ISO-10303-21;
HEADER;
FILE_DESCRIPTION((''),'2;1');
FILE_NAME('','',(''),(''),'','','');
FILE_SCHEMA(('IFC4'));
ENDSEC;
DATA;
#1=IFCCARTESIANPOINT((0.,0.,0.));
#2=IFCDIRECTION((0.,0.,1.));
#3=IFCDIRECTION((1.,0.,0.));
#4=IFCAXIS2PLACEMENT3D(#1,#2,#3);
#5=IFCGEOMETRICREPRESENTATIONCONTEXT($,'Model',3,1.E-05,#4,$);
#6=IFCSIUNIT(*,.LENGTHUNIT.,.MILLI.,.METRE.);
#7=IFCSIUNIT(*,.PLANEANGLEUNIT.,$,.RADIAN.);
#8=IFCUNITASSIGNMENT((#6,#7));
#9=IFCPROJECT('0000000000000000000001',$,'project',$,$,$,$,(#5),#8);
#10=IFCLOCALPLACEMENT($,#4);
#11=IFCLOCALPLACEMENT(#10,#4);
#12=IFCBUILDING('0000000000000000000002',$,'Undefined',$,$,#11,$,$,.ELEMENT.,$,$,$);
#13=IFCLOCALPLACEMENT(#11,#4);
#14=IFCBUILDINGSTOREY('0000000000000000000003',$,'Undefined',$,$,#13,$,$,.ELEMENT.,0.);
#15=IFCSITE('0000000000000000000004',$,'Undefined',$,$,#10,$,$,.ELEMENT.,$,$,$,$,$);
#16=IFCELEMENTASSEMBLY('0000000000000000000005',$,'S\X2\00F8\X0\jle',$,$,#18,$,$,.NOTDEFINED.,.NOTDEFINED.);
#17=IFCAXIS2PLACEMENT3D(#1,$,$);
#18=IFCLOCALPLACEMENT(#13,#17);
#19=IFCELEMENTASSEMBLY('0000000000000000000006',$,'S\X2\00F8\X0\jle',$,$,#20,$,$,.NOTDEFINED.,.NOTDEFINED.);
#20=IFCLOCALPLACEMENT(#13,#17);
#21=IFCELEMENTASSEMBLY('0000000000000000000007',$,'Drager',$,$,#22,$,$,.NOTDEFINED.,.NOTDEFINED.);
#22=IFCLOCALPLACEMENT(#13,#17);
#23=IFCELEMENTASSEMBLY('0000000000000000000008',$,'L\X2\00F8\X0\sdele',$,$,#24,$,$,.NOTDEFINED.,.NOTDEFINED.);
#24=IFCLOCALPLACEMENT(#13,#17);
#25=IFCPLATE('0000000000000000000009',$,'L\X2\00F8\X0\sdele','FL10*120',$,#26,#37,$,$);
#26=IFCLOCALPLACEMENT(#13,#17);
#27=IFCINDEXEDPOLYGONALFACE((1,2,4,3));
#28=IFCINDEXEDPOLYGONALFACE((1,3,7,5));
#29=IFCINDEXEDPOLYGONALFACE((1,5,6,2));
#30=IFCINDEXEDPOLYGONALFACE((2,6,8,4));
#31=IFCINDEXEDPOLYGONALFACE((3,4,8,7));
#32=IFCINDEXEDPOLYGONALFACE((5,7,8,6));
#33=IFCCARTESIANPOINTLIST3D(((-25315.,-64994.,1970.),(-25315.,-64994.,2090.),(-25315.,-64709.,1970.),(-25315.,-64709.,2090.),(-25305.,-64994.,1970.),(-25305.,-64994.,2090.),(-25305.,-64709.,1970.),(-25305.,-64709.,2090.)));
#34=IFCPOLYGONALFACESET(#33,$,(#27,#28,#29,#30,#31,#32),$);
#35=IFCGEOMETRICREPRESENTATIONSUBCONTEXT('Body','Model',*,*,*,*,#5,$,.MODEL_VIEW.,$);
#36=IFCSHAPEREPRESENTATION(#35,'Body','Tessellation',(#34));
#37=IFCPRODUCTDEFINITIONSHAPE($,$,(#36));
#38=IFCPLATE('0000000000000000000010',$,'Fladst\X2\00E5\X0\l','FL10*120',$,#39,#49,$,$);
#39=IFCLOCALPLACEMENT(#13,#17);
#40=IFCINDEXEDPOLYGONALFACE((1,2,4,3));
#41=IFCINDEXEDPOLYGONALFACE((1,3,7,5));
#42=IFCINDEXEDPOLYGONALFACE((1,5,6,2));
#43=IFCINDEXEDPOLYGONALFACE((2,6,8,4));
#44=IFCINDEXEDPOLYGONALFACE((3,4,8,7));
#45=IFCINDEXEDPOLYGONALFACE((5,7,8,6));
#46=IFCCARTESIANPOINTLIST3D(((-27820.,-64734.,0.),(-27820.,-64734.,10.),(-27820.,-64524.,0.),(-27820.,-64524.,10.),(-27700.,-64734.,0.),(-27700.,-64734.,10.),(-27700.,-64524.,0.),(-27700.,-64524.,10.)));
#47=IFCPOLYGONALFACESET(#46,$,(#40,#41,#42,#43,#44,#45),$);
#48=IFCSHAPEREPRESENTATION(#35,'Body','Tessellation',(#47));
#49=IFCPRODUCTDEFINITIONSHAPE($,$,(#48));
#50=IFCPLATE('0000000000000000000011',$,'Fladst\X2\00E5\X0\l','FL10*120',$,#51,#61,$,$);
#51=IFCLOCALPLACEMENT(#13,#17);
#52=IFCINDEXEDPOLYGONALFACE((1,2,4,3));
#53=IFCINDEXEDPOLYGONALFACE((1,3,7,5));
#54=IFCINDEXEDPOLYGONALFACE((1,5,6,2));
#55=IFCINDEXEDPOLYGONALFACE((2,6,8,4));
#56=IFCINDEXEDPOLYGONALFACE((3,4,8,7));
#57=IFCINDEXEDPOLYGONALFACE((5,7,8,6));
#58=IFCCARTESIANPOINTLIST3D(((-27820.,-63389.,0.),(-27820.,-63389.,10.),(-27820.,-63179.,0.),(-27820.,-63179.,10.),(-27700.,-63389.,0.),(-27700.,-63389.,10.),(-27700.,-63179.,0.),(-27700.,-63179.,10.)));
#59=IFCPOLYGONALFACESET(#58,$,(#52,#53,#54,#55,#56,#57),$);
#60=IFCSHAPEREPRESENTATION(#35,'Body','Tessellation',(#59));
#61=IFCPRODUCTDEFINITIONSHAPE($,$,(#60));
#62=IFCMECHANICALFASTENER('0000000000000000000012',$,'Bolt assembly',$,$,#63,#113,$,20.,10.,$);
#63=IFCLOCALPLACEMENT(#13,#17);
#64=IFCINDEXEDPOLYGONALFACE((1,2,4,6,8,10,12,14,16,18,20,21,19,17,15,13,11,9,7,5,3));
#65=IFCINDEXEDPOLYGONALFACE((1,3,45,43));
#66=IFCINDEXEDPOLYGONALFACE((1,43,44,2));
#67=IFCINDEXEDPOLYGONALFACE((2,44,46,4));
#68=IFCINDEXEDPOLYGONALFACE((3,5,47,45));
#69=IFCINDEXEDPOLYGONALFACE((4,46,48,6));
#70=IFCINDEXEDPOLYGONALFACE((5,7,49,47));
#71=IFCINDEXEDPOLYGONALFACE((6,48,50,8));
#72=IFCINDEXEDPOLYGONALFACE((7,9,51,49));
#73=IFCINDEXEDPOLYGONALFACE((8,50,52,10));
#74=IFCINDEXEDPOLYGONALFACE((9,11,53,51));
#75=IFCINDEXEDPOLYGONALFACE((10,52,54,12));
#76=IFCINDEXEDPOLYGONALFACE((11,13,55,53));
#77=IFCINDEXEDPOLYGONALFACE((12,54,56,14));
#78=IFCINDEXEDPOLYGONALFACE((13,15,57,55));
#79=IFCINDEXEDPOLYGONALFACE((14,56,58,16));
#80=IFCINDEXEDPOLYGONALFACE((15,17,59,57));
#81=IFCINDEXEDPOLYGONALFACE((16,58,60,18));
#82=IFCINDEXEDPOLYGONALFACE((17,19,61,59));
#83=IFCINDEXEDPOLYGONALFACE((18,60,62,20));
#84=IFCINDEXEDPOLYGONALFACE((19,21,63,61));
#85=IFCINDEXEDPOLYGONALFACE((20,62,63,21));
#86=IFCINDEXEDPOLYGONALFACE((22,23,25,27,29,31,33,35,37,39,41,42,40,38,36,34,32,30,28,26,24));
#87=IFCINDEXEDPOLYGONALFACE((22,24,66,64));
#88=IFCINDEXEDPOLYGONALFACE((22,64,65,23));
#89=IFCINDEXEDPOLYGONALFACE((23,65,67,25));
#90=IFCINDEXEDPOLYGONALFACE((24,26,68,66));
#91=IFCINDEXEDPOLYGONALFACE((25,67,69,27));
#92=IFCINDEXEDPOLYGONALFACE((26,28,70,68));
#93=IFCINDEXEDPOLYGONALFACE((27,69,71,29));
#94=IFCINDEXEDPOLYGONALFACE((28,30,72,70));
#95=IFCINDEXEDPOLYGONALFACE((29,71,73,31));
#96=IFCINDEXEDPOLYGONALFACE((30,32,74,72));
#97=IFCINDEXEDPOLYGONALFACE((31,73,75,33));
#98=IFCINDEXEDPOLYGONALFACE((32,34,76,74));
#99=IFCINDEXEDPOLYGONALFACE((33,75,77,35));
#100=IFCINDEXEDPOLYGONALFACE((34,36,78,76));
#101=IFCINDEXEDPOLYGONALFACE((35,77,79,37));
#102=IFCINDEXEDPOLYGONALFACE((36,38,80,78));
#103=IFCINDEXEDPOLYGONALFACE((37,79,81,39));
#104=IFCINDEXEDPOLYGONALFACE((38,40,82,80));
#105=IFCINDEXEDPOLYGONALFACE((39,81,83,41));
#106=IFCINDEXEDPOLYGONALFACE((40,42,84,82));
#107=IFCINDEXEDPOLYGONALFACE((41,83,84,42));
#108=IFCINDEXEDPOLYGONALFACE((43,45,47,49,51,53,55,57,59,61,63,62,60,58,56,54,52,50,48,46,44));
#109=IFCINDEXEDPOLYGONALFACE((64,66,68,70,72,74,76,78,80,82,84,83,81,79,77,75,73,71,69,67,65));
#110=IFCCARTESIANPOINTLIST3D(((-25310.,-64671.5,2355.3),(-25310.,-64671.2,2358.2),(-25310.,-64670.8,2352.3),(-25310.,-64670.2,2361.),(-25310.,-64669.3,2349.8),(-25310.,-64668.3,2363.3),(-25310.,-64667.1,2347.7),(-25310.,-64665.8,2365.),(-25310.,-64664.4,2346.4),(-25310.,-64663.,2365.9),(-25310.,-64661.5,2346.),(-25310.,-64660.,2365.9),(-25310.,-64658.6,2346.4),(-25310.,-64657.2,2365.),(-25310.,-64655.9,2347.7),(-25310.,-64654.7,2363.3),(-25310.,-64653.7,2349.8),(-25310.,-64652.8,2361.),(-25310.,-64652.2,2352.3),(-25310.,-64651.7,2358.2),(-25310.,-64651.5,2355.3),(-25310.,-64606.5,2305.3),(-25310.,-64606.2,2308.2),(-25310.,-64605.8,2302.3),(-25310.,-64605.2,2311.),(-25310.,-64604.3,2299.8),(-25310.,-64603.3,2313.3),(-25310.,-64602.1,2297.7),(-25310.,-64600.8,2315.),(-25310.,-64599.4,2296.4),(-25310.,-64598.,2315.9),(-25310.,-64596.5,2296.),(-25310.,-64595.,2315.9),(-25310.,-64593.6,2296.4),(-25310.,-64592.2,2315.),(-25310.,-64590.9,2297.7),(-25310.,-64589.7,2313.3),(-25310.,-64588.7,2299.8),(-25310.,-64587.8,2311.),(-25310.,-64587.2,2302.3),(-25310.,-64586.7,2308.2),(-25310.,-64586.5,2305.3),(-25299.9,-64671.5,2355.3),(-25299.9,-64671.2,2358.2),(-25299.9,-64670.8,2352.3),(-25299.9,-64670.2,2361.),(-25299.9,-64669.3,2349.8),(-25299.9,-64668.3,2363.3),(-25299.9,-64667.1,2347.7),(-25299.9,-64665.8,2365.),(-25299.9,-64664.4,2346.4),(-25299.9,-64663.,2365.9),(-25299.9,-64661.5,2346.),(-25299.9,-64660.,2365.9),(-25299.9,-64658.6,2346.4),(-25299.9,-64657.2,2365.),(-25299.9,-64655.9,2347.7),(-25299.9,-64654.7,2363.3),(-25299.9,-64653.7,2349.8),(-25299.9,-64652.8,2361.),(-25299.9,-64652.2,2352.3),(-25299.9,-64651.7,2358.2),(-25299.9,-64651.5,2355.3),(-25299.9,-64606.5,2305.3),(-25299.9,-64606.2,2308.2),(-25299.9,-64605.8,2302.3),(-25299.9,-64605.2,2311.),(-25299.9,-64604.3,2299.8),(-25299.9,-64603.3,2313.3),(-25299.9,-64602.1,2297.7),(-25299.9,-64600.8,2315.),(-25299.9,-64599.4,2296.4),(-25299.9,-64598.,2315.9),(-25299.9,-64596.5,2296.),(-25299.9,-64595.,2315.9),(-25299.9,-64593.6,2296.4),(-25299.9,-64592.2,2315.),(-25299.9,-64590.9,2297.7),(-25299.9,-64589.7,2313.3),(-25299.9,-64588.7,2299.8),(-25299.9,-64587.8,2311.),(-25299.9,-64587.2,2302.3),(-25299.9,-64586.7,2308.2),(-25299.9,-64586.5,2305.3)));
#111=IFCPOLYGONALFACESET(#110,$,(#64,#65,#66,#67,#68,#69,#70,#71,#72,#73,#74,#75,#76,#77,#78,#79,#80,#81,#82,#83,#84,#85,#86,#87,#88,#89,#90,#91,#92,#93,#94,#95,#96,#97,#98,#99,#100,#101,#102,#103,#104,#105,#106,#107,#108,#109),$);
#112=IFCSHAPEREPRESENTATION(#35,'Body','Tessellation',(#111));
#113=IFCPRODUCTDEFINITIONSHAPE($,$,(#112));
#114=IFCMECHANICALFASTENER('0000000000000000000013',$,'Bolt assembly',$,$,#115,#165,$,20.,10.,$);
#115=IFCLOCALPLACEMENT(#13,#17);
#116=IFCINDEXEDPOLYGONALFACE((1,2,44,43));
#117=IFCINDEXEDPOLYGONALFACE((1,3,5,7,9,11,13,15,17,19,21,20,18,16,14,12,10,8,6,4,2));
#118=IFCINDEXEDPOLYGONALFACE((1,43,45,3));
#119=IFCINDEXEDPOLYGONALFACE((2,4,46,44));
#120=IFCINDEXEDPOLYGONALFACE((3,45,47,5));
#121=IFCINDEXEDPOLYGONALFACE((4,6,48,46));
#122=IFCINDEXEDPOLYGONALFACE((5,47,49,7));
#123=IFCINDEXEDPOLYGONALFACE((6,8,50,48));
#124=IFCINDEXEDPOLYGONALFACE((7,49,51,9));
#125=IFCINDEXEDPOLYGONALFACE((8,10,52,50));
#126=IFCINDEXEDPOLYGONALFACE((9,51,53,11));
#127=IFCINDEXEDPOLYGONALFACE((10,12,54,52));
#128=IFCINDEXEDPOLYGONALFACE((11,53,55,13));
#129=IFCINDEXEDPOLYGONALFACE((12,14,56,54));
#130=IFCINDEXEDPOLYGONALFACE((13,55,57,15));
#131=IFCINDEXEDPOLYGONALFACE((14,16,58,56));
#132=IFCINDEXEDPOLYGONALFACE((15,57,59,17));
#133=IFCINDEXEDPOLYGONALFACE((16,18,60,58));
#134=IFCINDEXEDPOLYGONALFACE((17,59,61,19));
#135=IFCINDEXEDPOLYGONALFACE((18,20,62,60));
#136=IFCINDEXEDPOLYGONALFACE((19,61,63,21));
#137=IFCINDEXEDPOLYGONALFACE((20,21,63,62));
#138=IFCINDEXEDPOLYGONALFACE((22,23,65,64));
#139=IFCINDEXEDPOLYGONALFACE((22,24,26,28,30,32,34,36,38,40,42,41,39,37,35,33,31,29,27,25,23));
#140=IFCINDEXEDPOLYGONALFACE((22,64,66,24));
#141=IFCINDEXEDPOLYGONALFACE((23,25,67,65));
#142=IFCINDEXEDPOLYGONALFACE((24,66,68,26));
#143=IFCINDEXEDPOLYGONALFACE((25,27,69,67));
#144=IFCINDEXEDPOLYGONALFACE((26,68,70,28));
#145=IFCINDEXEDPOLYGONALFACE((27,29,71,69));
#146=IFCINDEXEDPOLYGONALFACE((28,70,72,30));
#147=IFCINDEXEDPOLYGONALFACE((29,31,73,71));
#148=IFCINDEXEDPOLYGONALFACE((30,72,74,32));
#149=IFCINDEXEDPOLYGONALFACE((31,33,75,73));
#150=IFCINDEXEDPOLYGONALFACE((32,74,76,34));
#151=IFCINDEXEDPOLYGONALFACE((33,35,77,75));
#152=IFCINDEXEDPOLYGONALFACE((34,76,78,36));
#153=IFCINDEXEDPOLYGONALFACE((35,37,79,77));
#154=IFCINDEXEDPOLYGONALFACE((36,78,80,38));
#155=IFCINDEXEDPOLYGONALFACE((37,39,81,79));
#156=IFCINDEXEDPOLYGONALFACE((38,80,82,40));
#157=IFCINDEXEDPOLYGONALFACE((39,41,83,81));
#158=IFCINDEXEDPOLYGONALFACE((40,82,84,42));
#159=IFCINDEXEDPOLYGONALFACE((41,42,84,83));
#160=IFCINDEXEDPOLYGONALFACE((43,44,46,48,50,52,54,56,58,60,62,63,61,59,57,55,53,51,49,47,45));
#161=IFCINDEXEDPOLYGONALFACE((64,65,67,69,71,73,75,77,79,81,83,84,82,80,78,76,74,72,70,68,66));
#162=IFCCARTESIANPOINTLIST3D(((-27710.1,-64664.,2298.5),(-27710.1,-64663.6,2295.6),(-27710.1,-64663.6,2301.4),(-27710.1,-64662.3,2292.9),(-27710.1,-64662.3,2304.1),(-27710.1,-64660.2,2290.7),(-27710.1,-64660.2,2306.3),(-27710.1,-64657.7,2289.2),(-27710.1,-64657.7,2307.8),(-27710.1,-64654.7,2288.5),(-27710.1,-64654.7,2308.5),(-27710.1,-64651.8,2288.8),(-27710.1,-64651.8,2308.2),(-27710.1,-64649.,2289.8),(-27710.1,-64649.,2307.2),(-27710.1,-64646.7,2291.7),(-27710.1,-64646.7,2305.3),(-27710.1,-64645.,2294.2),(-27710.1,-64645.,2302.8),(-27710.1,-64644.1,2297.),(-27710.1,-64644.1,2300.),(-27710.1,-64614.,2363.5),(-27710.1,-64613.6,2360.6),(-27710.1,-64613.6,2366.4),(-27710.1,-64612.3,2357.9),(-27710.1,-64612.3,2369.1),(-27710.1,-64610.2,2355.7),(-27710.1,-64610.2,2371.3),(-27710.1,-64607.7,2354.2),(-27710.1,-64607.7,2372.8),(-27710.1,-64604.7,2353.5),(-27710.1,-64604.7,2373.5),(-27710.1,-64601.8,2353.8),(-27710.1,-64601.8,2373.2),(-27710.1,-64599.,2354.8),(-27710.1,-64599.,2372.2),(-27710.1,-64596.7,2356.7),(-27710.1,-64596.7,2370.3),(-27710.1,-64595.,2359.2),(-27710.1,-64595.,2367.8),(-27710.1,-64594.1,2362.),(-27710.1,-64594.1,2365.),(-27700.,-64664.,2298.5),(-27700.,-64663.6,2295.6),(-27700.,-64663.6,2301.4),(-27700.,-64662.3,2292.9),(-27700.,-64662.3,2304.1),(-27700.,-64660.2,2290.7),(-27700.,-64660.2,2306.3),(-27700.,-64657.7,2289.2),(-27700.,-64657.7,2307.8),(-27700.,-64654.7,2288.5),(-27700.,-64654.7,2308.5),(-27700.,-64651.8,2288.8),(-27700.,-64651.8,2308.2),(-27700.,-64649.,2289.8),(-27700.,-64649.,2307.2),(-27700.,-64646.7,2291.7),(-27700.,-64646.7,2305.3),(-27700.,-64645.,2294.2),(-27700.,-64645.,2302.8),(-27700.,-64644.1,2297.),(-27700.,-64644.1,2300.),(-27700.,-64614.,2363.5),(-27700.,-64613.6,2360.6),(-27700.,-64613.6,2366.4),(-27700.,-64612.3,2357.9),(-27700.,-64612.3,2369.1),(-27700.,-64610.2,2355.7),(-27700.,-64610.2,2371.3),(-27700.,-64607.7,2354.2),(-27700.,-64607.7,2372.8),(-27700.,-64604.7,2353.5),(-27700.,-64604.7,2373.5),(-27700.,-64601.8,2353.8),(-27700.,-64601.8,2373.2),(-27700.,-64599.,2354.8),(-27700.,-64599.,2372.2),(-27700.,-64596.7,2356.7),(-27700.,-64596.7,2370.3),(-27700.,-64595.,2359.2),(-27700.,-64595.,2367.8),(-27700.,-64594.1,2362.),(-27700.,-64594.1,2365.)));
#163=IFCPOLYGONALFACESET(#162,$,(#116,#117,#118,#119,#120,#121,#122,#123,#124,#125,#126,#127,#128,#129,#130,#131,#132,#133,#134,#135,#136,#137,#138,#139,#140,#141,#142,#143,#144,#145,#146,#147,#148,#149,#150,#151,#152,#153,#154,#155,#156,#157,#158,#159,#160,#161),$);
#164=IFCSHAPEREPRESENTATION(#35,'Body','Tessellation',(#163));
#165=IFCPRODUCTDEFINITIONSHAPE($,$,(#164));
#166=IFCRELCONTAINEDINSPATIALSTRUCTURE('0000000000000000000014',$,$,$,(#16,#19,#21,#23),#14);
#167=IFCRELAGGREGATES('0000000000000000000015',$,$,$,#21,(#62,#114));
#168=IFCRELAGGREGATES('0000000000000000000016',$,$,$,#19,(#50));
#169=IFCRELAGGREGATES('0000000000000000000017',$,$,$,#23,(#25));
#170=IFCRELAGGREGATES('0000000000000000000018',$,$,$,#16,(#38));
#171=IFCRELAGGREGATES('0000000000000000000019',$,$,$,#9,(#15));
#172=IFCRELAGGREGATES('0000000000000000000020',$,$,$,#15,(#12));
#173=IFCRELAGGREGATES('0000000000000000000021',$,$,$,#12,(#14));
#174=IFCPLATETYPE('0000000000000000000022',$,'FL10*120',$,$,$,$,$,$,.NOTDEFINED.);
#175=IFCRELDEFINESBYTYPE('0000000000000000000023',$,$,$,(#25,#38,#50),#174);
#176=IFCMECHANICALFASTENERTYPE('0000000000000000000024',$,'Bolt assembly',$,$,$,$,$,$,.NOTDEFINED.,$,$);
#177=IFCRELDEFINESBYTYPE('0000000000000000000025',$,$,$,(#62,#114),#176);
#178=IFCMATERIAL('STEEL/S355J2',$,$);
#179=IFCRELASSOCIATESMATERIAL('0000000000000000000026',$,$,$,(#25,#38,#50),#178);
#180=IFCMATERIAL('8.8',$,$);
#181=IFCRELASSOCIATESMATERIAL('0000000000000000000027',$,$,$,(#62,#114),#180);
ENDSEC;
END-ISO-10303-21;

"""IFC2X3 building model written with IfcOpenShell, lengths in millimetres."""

from ifc_helpers import new_model, si_unit, frame, origin_with_axes, origin_2d_with_axis, place, context, subcontext, project, spatial, polyline, circle, outline, extrude, source, transform, mapped, material, type_object, element, aggregate, save


model = new_model("IFC2X3")

# Units and contexts
model_context = context("Model", 3, precision=1e-05, world=origin_with_axes())
body_context = subcontext(model_context, "Body", "Model", "MODEL_VIEW")
ifc_project = project(units=[si_unit("LENGTHUNIT", "METRE", prefix="MILLI"), si_unit("PLANEANGLEUNIT", "RADIAN")], contexts=[model_context])

# Site, building, storey
site_placement = place(None, origin_with_axes())
site = spatial("IfcSite", under=ifc_project, at=site_placement, Name="Undefined", CompositionType="ELEMENT")
building_placement = place(site_placement, origin_with_axes())
building = spatial("IfcBuilding", under=site, at=building_placement, Name="Undefined", CompositionType="ELEMENT")
storey_placement = place(building_placement, origin_with_axes())
storey = spatial("IfcBuildingStorey", under=building, at=storey_placement, Name="Undefined", CompositionType="ELEMENT", Elevation=0.0)

# Element assemblies
assembly_1_placement = place(storey_placement, origin_with_axes())
assembly_1 = element("IfcElementAssembly", 1, at=assembly_1_placement, inside=storey, Name="Søjle", AssemblyPlace="NOTDEFINED", PredefinedType="NOTDEFINED")
assembly_2_placement = place(storey_placement, origin_with_axes())
assembly_2 = element("IfcElementAssembly", 2, at=assembly_2_placement, inside=storey, Name="Søjle", AssemblyPlace="NOTDEFINED", PredefinedType="NOTDEFINED")

# Element assembly
assembly_3_placement = place(storey_placement, origin_with_axes())
assembly_3 = element("IfcElementAssembly", 3, at=assembly_3_placement, inside=storey, Name="Drager", AssemblyPlace="NOTDEFINED", PredefinedType="NOTDEFINED")

# Shared definitions
ifc_material_1 = material(Name="STEEL/S355J2")

# Element assembly, plate
plate_type_1 = type_object("IfcPlateType", Name="FL10*120", PredefinedType="NOTDEFINED")
assembly_4_placement = place(storey_placement, origin_with_axes())
assembly_4 = element("IfcElementAssembly", 4, at=assembly_4_placement, inside=storey, Name="Løsdele", AssemblyPlace="NOTDEFINED", PredefinedType="NOTDEFINED")
plate_1_placement = place(assembly_4_placement, frame((-25310.0, -64994.0, 2030.0), z_axis=(1.0, 0.0, 0.0), x_axis=(0.0, 1.0, 0.0)))
plate_1 = element("IfcPlate", 5, at=plate_1_placement, type_object=plate_type_1, material=ifc_material_1, Name="Løsdele", Description="FL10*120", context=body_context, shape_type="SweptSolid", body=[
    extrude(outline(polyline([(0.0, -60.0), (0.0, 60.0), (285.0, 60.0), (285.0, -60.0), (0.0, -60.0)])), frame((0.0, 0.0, -5.0), z_axis=(0.0, 0.0, 1.0), x_axis=(1.0, 0.0, 0.0)), (0.0, 0.0, 1.0), 10.0),
])

# Plates
plate_2_placement = place(assembly_1_placement, frame((-27700.0, -64629.0, 5.0), z_axis=(0.0, 0.0, 1.0), x_axis=(-1.0, 0.0, 0.0)))
plate_2 = element("IfcPlate", 6, at=plate_2_placement, type_object=plate_type_1, material=ifc_material_1, Name="Fladstål", Description="FL10*120", context=body_context, shape_type="SweptSolid", body=[
    extrude(outline(polyline([(0.0, -105.0), (0.0, 105.0), (120.0, 105.0), (120.0, -105.0), (0.0, -105.0)])), frame((0.0, 0.0, -5.0), z_axis=(0.0, 0.0, 1.0), x_axis=(1.0, 0.0, 0.0)), (0.0, 0.0, 1.0), 10.0),
])
plate_3_placement = place(assembly_2_placement, frame((-27700.0, -63284.0, 5.0), z_axis=(0.0, 0.0, 1.0), x_axis=(-1.0, 0.0, 0.0)))
plate_3 = element("IfcPlate", 7, at=plate_3_placement, type_object=plate_type_1, material=ifc_material_1, Name="Fladstål", Description="FL10*120", context=body_context, shape_type="SweptSolid", body=[
    extrude(outline(polyline([(0.0, -105.0), (0.0, 105.0), (120.0, 105.0), (120.0, -105.0), (0.0, -105.0)])), frame((0.0, 0.0, -5.0), z_axis=(0.0, 0.0, 1.0), x_axis=(1.0, 0.0, 0.0)), (0.0, 0.0, 1.0), 10.0),
])

# Mechanical fasteners
ifc_material_2 = material(Name="8.8")
mechanical_fastener_type = type_object("IfcMechanicalFastenerType", Name="Bolt assembly")
shared_shape_1 = source(origin_with_axes(), body_context, "Body", "SweptSolid", [
    extrude(circle(Radius=10.0, at=origin_2d_with_axis()), frame((0.0, 0.0, 0.0), z_axis=(0.0, 1.0, 0.0), x_axis=(1.0, 0.0, 0.0)), (0.0, 0.0, 1.0), 10.1),
])
mechanical_fastener_1_placement = place(assembly_3_placement, frame((-25310.0, -64629.0, 2356.0), z_axis=(0.0, -1.0, 0.0), x_axis=(0.0, 0.0, -1.0)))
mechanical_fastener_1 = element("IfcMechanicalFastener", 8, at=mechanical_fastener_1_placement, type_object=mechanical_fastener_type, material=ifc_material_2, Name="Bolt assembly", NominalDiameter=20.0, NominalLength=10.0, context=body_context, shape_type="MappedRepresentation", body=[
    mapped(shared_shape_1, transform((50.0, 0.0, -32.5))),
    mapped(shared_shape_1, transform((0.0, 0.0, 32.5))),
])
mechanical_fastener_2_placement = place(assembly_3_placement, frame((-27700.0, -64604.0, 2331.0), z_axis=(0.0, 0.0, -1.0), x_axis=(0.0, -1.0, 0.0)))
mechanical_fastener_2 = element("IfcMechanicalFastener", 9, at=mechanical_fastener_2_placement, type_object=mechanical_fastener_type, material=ifc_material_2, Name="Bolt assembly", NominalDiameter=20.0, NominalLength=10.0, context=body_context, shape_type="MappedRepresentation", body=[
    mapped(shared_shape_1, transform((0.0, 0.0, -32.5))),
    mapped(shared_shape_1, transform((50.0, 0.0, 32.5))),
])
aggregate(assembly_3, [mechanical_fastener_1, mechanical_fastener_2])
aggregate(assembly_2, [plate_3])
aggregate(assembly_4, [plate_1])
aggregate(assembly_1, [plate_2])

save(model, "model.ifc")
